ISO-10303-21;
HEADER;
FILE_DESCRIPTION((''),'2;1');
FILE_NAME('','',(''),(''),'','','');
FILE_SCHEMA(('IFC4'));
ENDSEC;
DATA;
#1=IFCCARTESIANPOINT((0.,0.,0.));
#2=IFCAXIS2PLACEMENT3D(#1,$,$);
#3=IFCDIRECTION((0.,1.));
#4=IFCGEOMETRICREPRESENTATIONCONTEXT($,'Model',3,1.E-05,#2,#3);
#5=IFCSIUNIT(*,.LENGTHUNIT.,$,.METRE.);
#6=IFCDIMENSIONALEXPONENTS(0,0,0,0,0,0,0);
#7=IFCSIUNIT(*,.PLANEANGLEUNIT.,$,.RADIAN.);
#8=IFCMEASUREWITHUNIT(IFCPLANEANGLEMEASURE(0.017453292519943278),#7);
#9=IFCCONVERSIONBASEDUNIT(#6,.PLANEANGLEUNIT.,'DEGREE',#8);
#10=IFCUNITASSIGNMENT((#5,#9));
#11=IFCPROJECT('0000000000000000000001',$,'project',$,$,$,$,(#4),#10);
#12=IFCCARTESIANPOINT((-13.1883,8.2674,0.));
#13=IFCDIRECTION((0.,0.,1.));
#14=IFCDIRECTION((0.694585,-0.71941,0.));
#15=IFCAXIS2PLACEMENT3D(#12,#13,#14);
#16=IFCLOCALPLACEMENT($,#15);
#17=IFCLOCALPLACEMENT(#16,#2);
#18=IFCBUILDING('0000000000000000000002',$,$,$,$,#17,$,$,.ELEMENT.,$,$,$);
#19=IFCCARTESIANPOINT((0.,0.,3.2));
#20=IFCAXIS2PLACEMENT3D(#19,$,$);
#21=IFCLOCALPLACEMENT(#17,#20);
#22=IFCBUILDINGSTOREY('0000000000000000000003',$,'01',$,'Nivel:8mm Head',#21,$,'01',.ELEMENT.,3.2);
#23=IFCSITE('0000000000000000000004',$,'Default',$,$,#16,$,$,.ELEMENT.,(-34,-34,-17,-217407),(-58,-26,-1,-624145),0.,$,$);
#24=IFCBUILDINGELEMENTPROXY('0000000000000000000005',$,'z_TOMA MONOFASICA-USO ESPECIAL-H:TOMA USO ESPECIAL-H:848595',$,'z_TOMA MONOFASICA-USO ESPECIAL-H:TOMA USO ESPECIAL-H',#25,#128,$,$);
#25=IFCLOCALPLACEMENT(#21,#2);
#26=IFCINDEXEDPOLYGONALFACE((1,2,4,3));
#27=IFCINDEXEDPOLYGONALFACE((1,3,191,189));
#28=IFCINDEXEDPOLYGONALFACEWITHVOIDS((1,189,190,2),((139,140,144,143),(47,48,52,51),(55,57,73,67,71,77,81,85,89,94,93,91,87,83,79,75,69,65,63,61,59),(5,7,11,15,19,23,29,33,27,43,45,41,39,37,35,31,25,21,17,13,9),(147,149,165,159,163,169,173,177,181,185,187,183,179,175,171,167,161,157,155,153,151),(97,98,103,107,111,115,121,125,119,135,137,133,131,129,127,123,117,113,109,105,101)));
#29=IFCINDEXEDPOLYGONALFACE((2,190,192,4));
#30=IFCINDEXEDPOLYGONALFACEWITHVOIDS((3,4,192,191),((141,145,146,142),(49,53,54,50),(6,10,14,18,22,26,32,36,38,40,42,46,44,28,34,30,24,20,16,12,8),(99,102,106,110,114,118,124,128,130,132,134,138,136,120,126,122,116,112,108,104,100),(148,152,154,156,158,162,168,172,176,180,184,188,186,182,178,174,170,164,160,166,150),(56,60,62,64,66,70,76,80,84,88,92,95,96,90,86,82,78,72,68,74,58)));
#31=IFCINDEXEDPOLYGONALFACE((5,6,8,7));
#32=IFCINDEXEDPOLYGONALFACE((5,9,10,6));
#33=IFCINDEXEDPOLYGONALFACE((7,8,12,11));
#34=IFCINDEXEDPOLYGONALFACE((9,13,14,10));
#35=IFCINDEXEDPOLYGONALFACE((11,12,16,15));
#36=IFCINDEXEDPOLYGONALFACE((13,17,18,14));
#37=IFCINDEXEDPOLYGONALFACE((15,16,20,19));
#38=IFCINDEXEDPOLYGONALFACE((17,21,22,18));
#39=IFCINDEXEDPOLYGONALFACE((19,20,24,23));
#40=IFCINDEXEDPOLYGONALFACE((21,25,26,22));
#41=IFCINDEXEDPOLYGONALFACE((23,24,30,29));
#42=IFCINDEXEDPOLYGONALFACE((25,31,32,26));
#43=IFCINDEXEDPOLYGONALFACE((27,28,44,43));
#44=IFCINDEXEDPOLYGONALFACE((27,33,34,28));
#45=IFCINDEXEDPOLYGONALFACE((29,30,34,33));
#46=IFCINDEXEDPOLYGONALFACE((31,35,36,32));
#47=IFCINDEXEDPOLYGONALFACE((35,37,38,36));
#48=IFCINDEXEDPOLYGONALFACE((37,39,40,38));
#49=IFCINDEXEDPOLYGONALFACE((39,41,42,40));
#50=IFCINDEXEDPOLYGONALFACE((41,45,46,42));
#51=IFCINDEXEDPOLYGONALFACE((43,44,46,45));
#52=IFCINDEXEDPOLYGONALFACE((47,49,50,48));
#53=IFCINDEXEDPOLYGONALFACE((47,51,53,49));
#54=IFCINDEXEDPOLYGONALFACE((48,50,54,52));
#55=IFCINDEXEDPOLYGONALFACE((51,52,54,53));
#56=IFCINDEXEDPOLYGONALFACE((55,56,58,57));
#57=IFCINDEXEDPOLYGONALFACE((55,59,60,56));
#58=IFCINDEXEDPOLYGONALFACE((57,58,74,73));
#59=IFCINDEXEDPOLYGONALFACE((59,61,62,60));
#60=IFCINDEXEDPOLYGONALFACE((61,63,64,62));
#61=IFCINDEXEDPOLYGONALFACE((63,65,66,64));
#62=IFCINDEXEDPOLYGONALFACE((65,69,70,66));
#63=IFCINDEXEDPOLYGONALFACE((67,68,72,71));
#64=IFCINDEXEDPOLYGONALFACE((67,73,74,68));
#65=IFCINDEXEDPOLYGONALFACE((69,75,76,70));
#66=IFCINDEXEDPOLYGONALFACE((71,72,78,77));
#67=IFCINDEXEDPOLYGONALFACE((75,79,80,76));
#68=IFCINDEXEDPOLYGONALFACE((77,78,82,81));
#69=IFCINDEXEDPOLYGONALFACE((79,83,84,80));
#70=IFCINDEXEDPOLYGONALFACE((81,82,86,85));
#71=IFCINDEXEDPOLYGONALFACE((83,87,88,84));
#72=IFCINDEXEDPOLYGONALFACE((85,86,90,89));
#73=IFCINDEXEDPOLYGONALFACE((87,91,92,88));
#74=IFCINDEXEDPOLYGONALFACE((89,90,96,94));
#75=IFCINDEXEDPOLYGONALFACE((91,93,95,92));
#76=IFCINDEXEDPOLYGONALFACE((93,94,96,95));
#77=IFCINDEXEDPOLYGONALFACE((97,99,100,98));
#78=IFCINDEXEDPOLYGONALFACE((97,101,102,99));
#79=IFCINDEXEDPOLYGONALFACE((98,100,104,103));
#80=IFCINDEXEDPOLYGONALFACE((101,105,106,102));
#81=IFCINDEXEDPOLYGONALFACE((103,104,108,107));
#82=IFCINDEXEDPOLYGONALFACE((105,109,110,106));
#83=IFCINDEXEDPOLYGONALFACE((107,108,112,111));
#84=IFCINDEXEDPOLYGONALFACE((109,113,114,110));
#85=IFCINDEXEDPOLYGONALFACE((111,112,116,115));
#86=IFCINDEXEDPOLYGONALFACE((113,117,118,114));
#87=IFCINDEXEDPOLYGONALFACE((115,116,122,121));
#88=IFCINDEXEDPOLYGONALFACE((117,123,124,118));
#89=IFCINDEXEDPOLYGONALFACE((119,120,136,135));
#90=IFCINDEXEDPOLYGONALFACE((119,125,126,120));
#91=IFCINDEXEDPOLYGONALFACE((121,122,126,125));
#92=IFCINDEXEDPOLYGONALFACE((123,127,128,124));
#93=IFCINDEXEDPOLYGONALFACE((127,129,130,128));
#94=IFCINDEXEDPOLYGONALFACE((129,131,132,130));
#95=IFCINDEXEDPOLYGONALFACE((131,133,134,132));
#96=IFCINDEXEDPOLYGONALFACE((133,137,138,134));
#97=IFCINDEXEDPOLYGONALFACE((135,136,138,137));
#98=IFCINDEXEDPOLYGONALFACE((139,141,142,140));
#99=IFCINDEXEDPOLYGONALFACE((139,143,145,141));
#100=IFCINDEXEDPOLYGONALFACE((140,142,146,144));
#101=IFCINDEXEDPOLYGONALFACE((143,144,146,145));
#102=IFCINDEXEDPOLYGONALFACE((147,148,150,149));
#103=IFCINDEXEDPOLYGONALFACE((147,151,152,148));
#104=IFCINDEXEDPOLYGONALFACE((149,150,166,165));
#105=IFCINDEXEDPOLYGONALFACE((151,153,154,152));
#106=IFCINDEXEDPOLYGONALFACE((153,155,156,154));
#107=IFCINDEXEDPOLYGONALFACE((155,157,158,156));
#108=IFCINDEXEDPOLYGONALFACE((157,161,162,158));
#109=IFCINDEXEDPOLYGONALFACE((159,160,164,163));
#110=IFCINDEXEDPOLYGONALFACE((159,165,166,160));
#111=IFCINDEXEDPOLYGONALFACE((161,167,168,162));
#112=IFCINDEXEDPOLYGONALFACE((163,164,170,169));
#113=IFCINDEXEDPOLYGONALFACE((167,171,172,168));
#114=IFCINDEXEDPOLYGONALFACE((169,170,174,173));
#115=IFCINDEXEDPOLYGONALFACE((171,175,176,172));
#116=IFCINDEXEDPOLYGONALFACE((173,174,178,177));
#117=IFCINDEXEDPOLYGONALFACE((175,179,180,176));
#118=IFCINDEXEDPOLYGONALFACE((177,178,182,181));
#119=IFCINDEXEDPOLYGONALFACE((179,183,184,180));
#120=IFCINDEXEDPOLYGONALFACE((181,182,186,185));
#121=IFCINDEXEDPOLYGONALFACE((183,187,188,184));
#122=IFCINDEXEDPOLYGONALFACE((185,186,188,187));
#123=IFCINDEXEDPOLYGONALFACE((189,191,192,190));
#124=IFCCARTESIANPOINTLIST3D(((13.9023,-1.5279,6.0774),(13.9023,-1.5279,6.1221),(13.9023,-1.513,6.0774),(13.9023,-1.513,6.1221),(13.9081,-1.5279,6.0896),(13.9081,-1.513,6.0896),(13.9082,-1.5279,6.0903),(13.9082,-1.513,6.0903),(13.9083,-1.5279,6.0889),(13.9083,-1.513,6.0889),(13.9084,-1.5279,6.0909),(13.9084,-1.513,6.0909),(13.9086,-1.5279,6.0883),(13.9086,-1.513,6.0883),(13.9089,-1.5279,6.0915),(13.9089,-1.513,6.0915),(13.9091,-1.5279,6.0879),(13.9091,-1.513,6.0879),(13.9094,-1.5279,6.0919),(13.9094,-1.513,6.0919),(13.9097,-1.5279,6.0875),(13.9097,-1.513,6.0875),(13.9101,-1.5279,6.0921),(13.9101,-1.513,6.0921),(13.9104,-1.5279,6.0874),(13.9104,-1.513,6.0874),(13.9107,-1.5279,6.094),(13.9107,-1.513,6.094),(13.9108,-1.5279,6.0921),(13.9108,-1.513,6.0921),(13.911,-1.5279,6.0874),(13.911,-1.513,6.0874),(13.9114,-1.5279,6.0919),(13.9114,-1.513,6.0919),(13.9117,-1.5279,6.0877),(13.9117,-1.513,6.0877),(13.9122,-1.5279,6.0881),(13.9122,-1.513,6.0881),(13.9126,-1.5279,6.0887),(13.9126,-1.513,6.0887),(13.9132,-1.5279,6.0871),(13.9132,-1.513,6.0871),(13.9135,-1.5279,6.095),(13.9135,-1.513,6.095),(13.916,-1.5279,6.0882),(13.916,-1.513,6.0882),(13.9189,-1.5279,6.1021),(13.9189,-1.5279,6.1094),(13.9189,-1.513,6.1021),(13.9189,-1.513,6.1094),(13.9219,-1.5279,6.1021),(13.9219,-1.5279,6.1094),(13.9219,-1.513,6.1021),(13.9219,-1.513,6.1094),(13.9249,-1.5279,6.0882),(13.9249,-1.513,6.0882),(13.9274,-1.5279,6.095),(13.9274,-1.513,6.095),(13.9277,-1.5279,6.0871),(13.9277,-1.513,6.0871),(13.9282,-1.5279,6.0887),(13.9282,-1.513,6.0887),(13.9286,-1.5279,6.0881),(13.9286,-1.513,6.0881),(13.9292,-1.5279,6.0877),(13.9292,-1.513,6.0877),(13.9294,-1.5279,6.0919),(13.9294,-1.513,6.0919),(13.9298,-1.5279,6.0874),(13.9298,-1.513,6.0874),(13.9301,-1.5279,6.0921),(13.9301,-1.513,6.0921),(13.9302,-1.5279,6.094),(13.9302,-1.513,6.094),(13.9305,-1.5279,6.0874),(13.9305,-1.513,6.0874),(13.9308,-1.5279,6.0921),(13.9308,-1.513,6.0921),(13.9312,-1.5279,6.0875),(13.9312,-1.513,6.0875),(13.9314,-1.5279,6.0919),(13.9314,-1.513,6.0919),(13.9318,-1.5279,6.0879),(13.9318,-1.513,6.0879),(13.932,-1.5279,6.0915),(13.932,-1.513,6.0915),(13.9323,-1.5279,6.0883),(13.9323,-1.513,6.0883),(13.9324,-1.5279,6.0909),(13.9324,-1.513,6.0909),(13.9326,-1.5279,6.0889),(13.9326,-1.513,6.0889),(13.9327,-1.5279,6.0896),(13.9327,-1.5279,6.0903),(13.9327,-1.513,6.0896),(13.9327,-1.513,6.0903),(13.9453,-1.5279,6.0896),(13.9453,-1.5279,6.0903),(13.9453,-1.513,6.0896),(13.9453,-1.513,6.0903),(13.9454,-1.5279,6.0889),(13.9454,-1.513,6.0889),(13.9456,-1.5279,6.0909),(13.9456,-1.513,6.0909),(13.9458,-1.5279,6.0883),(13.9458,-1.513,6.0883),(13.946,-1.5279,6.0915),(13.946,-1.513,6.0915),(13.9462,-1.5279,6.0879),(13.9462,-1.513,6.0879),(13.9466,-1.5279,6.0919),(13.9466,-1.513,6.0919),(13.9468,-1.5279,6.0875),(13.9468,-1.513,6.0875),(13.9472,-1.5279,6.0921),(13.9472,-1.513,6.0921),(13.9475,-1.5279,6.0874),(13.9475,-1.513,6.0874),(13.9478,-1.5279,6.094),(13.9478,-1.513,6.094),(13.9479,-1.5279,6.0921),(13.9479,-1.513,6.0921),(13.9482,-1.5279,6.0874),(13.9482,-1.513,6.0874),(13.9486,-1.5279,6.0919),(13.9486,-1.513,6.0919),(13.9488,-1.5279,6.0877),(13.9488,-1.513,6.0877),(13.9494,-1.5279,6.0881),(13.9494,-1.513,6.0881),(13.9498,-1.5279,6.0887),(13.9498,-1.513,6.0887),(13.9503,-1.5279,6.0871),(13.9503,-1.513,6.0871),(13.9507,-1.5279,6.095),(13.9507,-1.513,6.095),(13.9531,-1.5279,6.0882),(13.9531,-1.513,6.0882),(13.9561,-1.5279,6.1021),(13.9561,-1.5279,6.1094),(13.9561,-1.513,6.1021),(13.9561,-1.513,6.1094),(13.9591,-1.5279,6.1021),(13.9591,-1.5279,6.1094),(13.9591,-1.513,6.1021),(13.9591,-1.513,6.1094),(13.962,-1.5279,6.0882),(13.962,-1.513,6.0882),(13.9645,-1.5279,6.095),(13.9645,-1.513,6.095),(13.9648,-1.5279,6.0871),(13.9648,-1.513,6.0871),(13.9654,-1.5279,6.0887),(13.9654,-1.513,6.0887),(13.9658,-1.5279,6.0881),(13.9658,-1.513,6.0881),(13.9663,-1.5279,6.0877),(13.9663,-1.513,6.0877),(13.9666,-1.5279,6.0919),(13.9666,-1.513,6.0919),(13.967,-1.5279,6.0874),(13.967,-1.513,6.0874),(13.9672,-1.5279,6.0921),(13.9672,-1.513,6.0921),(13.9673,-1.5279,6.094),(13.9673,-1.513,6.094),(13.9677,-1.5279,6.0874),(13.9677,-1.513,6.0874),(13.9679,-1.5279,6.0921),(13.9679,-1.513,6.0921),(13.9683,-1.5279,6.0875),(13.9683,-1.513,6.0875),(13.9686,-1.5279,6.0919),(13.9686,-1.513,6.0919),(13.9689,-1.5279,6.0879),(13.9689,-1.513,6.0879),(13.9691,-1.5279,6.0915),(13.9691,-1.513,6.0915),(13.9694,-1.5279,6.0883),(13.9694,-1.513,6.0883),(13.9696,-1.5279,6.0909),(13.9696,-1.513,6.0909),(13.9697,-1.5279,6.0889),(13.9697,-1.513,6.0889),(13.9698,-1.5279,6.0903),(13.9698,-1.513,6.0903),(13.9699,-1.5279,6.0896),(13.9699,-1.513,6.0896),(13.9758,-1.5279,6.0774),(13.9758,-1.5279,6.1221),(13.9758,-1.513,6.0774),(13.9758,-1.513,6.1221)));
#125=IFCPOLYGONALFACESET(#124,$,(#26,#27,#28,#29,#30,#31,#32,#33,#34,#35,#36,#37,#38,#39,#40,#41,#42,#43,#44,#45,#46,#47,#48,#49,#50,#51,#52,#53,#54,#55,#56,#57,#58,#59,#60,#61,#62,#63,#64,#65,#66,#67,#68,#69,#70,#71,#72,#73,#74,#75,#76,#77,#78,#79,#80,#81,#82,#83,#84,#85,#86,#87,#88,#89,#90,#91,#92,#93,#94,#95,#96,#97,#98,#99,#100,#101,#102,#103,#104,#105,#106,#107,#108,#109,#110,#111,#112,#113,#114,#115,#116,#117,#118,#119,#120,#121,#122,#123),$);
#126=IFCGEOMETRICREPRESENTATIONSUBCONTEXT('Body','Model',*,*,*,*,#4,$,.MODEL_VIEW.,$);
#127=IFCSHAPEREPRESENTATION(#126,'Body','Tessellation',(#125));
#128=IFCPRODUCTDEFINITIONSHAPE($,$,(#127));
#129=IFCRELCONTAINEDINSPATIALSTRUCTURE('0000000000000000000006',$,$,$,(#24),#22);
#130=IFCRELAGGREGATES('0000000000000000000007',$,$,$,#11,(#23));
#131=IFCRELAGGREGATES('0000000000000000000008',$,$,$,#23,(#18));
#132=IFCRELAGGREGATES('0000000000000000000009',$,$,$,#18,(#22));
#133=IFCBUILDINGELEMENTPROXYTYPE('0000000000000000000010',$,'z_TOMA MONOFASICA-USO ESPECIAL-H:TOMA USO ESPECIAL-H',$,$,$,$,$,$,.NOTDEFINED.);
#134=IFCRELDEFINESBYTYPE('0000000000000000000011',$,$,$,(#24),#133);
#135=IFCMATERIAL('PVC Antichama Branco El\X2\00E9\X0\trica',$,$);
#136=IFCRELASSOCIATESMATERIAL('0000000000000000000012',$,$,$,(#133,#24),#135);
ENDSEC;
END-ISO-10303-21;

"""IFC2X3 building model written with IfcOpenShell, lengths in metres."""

from ifc_helpers import new_model, entity, si_unit, converted_unit, direction, frame, frame_2d, origin, place, context, subcontext, project, spatial, polyline, circle_curve, parameter, trimmed, segment, composite_curve, outline, extrude, source, transform, mapped, material, type_object, type_shapes, element, save


model = new_model("IFC2X3")

# Units and contexts
model_context = context("Model", 3, precision=1e-05, world=origin(), true_north=direction((0.0, 1.0)))
body_context = subcontext(model_context, "Body", "Model", "MODEL_VIEW")
ifc_project = project(units=[si_unit("LENGTHUNIT", "METRE"), converted_unit("PLANEANGLEUNIT", "DEGREE", entity("IfcPlaneAngleMeasure", 0.017453292519943278), si_unit("PLANEANGLEUNIT", "RADIAN"), dimensions=[0, 0, 0, 0, 0, 0, 0])], contexts=[model_context])

# Site, building, storey
site_placement = place(None, frame((-13.1883, 8.2674, 0.0), z_axis=(0.0, 0.0, 1.0), x_axis=(0.694585, -0.71941, 0.0)))
site = spatial("IfcSite", under=ifc_project, at=site_placement, Name="Default", CompositionType="ELEMENT", RefLatitude=(-34, -34, -17, -217407), RefLongitude=(-58, -26, -1, -624145), RefElevation=0.0)
building_placement = place(site_placement, origin())
building = spatial("IfcBuilding", under=site, at=building_placement, CompositionType="ELEMENT")
storey_placement = place(building_placement, frame((0.0, 0.0, 3.2)))
storey = spatial("IfcBuildingStorey", under=building, at=storey_placement, Name="01", ObjectType="Nivel:8mm Head", LongName="01", CompositionType="ELEMENT", Elevation=3.2)

# Building element proxy
ifc_material_1 = material(Name="PVC Antichama Branco Elétrica")
building_element_proxy_type_1 = type_object("IfcBuildingElementProxyType", Name="z_TOMA MONOFASICA-USO ESPECIAL-H:TOMA USO ESPECIAL-H", PredefinedType="NOTDEFINED", material=ifc_material_1)
shared_shape_1 = source(origin(), body_context, "Body", "SweptSolid", [
    extrude(outline(polyline([(-0.0368, -0.0223), (0.0368, -0.0223), (0.0368, 0.0223), (-0.0368, 0.0223), (-0.0368, -0.0223)]), holes=[composite_curve([segment(polyline([(0.0141, 0.0115), (0.0116, 0.0047)]), True, "CONTINUOUS"), segment(polyline([(0.0116, 0.0047), (0.0088, 0.0057)]), True, "CONTINUOUS"), segment(polyline([(0.0088, 0.0057), (0.0096, 0.0078)]), True, "CONTINUOUS"), segment(trimmed(circle_curve(frame_2d((0.0087, 0.0099), x_axis=(1.0, 0.0)), 0.0024), [parameter(27.118901)], [parameter(292.881099)], True, "PARAMETER"), False, "CONTINUOUS"), segment(polyline([(0.0108, 0.011), (0.0113, 0.0126)]), True, "CONTINUOUS"), segment(polyline([(0.0113, 0.0126), (0.0141, 0.0115)]), True, "CONTINUOUS")], self_intersect=False), composite_curve([segment(polyline([(0.0255, 0.0047), (0.023, 0.0115)]), True, "CONTINUOUS"), segment(polyline([(0.023, 0.0115), (0.0258, 0.0126)]), True, "CONTINUOUS"), segment(polyline([(0.0258, 0.0126), (0.0264, 0.011)]), True, "CONTINUOUS"), segment(trimmed(circle_curve(frame_2d((0.0285, 0.0099), x_axis=(1.0, 0.0)), 0.0024), [parameter(247.118901)], [parameter(152.881099)], True, "PARAMETER"), False, "CONTINUOUS"), segment(polyline([(0.0276, 0.0078), (0.0283, 0.0057)]), True, "CONTINUOUS"), segment(polyline([(0.0283, 0.0057), (0.0255, 0.0047)]), True, "CONTINUOUS")], self_intersect=False), polyline([(0.0201, -0.0024), (0.0201, -0.0097), (0.0171, -0.0097), (0.0171, -0.0024), (0.0201, -0.0024)]), composite_curve([segment(polyline([(-0.0141, 0.0115), (-0.0113, 0.0126)]), True, "CONTINUOUS"), segment(polyline([(-0.0113, 0.0126), (-0.0108, 0.011)]), True, "CONTINUOUS"), segment(trimmed(circle_curve(frame_2d((-0.0087, 0.0099), x_axis=(1.0, 0.0)), 0.0024), [parameter(247.118901)], [parameter(152.881099)], True, "PARAMETER"), False, "CONTINUOUS"), segment(polyline([(-0.0096, 0.0078), (-0.0088, 0.0057)]), True, "CONTINUOUS"), segment(polyline([(-0.0088, 0.0057), (-0.0116, 0.0047)]), True, "CONTINUOUS"), segment(polyline([(-0.0116, 0.0047), (-0.0141, 0.0115)]), True, "CONTINUOUS")], self_intersect=False), composite_curve([segment(polyline([(-0.0255, 0.0047), (-0.0283, 0.0057)]), True, "CONTINUOUS"), segment(polyline([(-0.0283, 0.0057), (-0.0276, 0.0078)]), True, "CONTINUOUS"), segment(trimmed(circle_curve(frame_2d((-0.0285, 0.0099), x_axis=(1.0, 0.0)), 0.0024), [parameter(27.118901)], [parameter(292.881099)], True, "PARAMETER"), False, "CONTINUOUS"), segment(polyline([(-0.0264, 0.011), (-0.0258, 0.0126)]), True, "CONTINUOUS"), segment(polyline([(-0.0258, 0.0126), (-0.023, 0.0115)]), True, "CONTINUOUS"), segment(polyline([(-0.023, 0.0115), (-0.0255, 0.0047)]), True, "CONTINUOUS")], self_intersect=False), polyline([(-0.0201, -0.0024), (-0.0171, -0.0024), (-0.0171, -0.0097), (-0.0201, -0.0097), (-0.0201, -0.0024)])]), frame((0.0, -0.005, 0.0223), z_axis=(0.0, 1.0, 0.0), x_axis=(1.0, 0.0, 0.0)), (0.0, 0.0, 1.0), 0.0148),
])
type_shapes(building_element_proxy_type_1, [shared_shape_1])
for number, where, name in (
    (1, (13.939, -1.5229, 6.0774), "z_TOMA MONOFASICA-USO ESPECIAL-H:TOMA USO ESPECIAL-H:848595"),
):
    element("IfcBuildingElementProxy", number, at=place(storey_placement, frame(where)), inside=storey, type_object=building_element_proxy_type_1, material=ifc_material_1, Name=name, ObjectType="z_TOMA MONOFASICA-USO ESPECIAL-H:TOMA USO ESPECIAL-H", context=body_context, shape_type="MappedRepresentation", body=[
        mapped(shared_shape_1, transform((0.0, 0.0, 0.0), scale=1.0)),
    ])

save(model, "model.ifc")
